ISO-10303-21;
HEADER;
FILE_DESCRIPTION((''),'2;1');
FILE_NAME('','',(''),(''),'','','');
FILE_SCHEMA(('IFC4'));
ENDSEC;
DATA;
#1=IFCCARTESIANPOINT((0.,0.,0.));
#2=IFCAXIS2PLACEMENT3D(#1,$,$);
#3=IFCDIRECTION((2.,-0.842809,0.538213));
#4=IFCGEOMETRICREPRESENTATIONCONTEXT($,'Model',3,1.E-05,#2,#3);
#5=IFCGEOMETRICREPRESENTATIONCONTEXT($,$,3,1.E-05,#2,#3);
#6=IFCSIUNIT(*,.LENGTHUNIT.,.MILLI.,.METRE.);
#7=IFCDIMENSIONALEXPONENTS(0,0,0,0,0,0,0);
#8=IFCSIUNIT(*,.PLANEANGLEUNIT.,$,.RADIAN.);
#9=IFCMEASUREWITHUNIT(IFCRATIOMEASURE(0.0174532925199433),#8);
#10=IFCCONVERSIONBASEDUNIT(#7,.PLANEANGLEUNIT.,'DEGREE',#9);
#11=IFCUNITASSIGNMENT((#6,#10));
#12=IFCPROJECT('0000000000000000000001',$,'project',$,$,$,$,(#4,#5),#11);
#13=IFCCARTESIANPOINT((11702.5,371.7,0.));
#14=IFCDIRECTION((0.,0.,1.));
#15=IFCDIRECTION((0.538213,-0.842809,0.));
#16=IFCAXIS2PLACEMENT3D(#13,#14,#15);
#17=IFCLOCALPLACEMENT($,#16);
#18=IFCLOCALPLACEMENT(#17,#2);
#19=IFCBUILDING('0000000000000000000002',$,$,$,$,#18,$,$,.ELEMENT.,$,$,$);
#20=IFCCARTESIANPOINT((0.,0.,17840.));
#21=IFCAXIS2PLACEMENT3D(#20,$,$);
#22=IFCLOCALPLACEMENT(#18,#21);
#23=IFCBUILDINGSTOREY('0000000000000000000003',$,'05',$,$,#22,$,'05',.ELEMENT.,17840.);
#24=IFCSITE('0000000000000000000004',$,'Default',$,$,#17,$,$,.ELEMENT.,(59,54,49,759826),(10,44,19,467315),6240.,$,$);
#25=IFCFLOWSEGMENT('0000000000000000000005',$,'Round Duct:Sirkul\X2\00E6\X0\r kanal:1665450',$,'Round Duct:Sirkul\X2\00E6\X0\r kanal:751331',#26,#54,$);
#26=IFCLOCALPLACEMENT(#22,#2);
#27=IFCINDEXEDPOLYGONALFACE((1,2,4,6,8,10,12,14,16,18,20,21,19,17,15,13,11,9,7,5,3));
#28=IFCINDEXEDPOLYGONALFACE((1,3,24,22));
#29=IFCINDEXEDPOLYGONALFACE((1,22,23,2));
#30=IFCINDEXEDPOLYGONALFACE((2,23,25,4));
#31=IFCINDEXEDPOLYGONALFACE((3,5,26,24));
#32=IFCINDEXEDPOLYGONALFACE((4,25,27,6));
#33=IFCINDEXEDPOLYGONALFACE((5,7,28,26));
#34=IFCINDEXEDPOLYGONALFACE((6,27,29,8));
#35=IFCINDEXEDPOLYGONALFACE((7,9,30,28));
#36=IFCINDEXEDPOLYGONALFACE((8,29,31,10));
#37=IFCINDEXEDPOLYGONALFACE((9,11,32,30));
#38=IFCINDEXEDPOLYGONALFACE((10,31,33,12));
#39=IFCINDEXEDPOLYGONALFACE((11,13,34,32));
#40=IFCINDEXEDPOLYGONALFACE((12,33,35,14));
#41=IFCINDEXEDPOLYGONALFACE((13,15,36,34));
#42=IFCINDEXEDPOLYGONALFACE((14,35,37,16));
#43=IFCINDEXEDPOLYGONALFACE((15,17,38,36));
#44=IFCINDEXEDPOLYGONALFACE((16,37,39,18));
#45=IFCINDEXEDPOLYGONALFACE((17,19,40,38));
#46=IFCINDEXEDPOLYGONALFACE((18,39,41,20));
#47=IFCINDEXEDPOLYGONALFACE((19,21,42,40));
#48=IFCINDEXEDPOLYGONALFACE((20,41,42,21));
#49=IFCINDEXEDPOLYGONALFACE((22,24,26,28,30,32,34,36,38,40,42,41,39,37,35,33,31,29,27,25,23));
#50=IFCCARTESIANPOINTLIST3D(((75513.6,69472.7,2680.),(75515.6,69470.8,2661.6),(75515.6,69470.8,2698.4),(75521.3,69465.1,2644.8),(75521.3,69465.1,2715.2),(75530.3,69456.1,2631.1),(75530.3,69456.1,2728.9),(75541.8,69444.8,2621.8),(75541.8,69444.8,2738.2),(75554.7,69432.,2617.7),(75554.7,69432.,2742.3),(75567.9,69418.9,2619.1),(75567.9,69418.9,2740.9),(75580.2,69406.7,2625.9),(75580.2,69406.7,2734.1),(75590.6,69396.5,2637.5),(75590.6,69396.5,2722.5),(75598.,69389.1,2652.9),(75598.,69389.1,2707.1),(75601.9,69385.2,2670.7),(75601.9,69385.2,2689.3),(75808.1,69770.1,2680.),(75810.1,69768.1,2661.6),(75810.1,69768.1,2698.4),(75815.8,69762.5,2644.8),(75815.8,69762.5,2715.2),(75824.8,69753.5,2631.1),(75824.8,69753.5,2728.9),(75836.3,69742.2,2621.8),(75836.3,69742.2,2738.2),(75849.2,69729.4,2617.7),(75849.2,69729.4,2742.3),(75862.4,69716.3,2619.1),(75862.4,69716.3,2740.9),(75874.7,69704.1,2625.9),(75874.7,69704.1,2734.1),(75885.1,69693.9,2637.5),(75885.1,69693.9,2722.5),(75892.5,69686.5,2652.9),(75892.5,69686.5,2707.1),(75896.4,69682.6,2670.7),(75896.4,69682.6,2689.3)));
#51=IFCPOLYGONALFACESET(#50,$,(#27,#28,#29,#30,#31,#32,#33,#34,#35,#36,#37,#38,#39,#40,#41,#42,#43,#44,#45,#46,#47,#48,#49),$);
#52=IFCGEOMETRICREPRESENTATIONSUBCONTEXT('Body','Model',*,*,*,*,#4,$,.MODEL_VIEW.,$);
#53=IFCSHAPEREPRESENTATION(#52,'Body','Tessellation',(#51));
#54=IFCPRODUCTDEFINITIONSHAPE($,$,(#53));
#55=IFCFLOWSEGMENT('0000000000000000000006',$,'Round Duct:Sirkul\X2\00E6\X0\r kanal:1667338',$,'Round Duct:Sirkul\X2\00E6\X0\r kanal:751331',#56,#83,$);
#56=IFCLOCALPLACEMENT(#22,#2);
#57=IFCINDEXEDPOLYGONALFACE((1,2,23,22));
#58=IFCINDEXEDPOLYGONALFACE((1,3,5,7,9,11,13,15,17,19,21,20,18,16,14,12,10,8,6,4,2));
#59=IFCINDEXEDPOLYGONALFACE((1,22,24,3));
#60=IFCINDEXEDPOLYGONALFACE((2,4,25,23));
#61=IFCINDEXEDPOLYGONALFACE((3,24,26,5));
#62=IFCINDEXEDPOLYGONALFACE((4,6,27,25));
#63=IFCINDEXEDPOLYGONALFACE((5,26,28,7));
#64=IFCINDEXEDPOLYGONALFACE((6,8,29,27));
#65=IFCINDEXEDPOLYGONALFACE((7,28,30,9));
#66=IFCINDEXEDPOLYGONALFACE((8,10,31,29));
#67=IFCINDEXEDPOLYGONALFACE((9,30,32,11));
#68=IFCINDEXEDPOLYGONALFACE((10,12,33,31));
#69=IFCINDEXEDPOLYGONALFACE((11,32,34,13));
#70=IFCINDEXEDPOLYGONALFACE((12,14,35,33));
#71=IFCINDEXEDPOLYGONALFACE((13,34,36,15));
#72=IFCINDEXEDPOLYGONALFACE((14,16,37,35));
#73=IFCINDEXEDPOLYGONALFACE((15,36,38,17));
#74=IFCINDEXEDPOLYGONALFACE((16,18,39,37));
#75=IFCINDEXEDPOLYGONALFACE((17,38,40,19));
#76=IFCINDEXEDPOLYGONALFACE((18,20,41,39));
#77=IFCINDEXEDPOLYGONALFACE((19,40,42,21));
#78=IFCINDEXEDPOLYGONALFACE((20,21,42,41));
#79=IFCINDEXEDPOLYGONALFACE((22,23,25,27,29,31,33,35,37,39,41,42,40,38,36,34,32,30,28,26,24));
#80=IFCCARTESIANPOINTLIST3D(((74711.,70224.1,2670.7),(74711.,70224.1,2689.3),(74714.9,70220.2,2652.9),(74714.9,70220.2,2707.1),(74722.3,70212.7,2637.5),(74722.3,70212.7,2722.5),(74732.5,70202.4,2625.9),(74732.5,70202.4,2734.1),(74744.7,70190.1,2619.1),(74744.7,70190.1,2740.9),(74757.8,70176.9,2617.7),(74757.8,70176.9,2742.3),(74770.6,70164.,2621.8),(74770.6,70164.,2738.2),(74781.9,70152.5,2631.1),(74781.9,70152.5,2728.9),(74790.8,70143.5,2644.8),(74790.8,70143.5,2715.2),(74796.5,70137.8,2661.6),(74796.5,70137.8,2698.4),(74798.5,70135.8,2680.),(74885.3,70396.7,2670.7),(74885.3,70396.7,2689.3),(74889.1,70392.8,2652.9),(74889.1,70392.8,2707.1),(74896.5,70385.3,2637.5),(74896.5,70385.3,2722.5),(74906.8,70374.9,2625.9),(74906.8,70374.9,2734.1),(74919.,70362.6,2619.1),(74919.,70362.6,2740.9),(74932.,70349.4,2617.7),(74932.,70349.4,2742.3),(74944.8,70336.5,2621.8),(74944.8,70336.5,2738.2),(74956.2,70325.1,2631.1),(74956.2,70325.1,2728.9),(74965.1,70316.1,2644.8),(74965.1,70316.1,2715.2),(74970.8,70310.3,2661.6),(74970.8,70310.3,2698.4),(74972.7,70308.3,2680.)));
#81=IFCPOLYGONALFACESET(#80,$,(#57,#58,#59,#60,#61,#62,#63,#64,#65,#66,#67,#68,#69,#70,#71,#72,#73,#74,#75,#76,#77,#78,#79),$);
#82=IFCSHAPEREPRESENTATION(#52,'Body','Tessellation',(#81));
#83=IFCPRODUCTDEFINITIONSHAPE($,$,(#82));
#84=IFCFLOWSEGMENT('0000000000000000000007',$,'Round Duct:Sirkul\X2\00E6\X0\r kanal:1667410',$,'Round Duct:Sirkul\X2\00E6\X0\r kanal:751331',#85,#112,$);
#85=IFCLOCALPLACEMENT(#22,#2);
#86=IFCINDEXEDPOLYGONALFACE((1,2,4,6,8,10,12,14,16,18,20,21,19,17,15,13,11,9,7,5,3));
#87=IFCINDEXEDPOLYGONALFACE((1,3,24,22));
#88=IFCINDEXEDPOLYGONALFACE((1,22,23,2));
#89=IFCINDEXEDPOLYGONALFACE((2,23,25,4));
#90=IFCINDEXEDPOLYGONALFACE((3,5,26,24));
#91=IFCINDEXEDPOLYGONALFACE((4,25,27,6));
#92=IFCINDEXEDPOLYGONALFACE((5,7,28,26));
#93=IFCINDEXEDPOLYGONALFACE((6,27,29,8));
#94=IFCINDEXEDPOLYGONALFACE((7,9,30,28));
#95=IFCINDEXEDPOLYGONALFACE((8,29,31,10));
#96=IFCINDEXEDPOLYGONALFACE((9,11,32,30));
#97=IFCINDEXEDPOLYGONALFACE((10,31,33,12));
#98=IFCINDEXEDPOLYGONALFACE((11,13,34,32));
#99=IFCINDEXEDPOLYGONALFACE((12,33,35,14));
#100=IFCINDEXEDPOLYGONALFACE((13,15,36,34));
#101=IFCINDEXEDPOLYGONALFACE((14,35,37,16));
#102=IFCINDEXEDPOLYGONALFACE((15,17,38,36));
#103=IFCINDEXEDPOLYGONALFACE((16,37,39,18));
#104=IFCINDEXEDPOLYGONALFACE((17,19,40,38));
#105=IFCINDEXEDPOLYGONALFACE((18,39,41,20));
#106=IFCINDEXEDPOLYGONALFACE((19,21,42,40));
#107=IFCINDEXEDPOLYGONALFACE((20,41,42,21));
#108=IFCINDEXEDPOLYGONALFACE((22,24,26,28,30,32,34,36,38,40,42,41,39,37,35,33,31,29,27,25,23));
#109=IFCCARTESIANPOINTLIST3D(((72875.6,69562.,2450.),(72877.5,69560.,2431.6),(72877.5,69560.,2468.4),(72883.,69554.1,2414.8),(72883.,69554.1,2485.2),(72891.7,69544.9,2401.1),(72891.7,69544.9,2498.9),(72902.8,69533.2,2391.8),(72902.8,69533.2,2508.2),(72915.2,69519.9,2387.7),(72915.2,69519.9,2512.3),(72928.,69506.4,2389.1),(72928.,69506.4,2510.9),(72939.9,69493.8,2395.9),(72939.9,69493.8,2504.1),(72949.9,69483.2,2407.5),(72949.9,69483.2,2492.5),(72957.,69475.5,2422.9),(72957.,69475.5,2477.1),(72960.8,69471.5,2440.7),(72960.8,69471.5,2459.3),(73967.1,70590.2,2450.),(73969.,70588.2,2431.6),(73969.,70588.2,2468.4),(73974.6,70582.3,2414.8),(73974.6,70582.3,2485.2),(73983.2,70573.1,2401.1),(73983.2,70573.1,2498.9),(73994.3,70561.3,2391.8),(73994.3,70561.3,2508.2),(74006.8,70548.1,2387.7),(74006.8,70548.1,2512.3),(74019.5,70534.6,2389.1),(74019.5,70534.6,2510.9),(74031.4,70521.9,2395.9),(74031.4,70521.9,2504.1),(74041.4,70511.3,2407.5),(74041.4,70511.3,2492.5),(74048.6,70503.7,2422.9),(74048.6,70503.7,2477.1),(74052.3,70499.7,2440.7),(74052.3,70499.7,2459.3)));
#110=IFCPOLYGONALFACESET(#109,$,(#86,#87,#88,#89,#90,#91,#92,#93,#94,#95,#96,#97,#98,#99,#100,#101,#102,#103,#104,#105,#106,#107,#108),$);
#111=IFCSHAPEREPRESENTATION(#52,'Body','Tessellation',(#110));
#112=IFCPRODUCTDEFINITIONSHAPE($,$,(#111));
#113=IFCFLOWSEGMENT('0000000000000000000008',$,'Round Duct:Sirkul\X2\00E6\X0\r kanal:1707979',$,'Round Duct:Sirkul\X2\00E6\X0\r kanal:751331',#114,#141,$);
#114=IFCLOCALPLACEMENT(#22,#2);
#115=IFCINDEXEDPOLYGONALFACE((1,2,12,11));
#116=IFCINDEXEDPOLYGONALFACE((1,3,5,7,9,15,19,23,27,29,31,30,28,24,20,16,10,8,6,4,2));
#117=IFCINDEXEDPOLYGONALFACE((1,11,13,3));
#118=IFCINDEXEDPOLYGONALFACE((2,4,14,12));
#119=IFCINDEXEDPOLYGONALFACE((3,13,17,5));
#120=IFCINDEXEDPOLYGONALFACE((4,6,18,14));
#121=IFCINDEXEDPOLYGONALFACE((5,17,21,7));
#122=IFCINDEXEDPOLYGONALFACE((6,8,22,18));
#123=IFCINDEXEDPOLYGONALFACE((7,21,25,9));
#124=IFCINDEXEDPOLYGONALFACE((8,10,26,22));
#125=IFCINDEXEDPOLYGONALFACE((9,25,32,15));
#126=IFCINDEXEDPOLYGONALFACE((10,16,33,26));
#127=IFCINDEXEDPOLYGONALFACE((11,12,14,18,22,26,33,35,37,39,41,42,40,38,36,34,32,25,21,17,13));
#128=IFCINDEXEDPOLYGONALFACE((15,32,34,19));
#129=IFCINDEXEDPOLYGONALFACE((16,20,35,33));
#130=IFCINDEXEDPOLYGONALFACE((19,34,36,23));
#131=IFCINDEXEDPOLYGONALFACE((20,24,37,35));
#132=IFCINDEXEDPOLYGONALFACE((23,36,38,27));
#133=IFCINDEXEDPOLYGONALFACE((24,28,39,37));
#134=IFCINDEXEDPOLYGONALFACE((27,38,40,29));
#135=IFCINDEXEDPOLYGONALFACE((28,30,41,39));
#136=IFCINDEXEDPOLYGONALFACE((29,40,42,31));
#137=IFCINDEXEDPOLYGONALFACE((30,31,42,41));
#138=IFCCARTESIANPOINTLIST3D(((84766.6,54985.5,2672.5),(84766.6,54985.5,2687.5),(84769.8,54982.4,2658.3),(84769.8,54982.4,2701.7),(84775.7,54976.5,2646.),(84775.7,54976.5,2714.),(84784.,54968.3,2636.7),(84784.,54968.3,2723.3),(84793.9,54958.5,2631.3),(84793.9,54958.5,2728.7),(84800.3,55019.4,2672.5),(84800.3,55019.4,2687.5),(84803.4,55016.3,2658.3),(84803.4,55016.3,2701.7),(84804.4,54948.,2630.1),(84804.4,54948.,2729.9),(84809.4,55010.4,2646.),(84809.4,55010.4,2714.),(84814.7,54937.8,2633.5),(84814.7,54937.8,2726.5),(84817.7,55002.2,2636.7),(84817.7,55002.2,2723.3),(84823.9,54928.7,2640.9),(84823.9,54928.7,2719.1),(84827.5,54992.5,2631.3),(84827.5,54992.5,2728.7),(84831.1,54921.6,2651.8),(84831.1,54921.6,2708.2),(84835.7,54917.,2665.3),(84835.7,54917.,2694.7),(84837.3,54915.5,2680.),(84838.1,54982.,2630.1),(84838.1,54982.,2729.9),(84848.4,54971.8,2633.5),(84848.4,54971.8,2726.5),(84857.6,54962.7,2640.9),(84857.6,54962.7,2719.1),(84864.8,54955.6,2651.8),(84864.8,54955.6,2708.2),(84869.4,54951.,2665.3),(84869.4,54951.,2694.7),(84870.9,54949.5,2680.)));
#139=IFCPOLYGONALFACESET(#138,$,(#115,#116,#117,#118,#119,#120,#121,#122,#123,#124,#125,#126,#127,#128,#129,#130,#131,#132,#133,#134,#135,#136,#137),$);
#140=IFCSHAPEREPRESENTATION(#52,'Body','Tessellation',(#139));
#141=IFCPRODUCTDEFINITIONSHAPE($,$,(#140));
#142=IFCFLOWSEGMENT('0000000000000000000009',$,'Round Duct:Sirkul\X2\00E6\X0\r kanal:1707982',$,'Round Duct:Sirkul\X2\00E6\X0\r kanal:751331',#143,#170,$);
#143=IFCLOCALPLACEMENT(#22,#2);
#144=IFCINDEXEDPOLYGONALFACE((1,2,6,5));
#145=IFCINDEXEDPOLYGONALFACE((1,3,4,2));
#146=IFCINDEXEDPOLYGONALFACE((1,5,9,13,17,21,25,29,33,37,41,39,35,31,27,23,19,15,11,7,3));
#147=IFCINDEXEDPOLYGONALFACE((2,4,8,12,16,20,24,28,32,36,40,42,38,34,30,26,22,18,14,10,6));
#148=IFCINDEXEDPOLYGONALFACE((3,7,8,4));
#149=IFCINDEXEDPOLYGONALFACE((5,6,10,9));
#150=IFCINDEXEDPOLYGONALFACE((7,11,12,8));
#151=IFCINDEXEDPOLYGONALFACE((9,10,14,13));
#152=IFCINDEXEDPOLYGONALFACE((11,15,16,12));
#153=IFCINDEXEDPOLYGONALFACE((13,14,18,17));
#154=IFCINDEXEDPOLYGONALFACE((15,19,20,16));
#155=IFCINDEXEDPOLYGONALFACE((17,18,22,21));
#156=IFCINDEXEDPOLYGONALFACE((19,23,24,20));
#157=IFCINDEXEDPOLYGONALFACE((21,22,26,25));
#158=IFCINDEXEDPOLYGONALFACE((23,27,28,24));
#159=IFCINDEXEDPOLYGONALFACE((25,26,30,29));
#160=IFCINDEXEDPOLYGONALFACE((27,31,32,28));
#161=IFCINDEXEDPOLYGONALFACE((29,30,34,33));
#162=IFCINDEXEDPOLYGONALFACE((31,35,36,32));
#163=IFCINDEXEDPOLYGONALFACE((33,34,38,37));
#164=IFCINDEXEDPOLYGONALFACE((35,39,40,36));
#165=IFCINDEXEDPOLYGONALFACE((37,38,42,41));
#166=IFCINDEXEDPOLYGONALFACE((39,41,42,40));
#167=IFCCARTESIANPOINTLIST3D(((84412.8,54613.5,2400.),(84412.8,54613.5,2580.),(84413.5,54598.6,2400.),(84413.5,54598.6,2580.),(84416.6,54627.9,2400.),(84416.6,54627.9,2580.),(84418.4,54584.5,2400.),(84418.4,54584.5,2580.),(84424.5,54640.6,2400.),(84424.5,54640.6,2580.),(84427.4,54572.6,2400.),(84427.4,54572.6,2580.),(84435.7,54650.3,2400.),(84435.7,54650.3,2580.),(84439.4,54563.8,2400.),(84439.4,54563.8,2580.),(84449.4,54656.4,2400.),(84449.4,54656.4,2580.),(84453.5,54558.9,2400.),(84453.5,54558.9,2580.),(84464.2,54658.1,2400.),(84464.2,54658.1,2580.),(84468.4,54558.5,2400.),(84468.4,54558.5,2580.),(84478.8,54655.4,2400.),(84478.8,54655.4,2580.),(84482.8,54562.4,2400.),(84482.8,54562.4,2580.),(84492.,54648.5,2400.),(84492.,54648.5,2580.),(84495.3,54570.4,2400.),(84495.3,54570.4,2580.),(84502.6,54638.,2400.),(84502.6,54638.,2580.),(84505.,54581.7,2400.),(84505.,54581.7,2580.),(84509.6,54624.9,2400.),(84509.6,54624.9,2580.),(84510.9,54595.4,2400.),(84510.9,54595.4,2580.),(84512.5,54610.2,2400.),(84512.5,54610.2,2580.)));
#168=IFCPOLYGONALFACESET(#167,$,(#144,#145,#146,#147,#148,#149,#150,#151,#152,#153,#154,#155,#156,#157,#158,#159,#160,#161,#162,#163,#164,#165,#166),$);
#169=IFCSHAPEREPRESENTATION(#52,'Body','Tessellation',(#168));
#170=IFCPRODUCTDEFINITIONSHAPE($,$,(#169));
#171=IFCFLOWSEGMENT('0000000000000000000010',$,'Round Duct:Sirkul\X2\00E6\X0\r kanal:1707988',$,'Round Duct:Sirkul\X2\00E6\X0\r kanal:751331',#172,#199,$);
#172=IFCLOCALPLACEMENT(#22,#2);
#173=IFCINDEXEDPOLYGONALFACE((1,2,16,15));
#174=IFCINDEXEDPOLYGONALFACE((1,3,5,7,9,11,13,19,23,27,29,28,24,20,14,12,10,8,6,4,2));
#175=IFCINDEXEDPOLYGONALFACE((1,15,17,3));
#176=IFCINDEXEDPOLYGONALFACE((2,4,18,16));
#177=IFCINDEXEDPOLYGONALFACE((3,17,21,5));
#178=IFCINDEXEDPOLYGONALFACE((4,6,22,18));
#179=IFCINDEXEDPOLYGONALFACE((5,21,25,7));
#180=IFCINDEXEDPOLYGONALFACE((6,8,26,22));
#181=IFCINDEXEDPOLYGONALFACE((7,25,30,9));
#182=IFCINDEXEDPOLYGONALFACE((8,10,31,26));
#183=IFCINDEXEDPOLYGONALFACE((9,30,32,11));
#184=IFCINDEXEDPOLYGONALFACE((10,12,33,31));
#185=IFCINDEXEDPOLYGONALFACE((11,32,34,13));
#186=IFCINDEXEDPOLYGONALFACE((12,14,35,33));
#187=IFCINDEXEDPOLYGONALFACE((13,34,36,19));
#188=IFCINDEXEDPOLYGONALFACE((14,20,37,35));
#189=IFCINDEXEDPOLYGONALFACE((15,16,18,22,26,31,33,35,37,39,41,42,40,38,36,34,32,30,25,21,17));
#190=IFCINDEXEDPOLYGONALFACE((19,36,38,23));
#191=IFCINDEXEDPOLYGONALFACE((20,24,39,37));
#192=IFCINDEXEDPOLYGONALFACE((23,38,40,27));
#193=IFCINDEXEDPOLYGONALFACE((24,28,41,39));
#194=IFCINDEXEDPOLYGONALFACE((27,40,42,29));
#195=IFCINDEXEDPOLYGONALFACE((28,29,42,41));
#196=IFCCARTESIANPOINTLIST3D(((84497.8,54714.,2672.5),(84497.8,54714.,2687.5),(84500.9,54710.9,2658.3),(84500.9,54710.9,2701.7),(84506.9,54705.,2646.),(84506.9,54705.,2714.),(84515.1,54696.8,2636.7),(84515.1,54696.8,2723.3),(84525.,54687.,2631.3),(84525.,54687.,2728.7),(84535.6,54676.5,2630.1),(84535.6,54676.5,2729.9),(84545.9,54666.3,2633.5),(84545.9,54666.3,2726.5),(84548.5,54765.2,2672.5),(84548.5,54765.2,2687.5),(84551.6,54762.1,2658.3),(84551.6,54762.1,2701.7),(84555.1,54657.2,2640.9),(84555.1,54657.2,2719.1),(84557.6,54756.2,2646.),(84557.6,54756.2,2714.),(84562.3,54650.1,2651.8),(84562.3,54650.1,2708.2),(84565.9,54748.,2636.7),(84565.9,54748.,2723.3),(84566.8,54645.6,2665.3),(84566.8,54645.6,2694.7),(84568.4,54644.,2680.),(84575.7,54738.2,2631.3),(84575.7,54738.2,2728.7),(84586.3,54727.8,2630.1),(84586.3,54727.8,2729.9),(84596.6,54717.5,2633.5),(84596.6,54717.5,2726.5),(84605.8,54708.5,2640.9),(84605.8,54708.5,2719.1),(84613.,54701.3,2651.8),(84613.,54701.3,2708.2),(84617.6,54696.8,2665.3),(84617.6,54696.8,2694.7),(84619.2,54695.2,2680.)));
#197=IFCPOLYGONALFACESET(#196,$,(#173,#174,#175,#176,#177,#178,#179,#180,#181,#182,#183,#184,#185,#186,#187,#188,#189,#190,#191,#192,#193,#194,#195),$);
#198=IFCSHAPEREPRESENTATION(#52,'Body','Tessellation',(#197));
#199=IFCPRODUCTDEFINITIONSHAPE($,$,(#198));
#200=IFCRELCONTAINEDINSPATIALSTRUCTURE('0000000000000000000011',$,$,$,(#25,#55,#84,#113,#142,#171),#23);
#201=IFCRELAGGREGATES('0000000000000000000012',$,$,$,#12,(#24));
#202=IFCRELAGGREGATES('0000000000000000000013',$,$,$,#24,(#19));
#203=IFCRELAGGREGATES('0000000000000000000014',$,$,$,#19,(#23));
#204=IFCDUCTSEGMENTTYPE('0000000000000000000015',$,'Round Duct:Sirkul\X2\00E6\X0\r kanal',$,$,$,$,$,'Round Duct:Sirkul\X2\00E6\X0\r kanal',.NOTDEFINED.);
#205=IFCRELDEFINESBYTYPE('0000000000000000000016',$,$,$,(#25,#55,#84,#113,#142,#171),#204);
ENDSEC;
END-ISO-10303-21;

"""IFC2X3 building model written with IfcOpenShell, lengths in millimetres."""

from ifc_helpers import new_model, entity, si_unit, converted_unit, direction, frame, frame_2d, origin, origin_2d_with_axis, place, context, subcontext, project, spatial, circle, extrude, type_object, element, save


model = new_model("IFC2X3")

# Units and contexts
model_context = context("Model", 3, precision=1e-05, world=origin(), true_north=direction((2.0, -0.842809, 0.538213)))
context_of_model = context(None, 3, precision=1e-05, world=origin(), true_north=direction((2.0, -0.842809, 0.538213)))
body_context = subcontext(model_context, "Body", "Model", "MODEL_VIEW")
ifc_project = project(units=[si_unit("LENGTHUNIT", "METRE", prefix="MILLI"), converted_unit("PLANEANGLEUNIT", "DEGREE", entity("IfcRatioMeasure", 0.0174532925199433), si_unit("PLANEANGLEUNIT", "RADIAN"), dimensions=[0, 0, 0, 0, 0, 0, 0])], contexts=[model_context, context_of_model])

# Site, building, storey
site_placement = place(None, frame((11702.5, 371.7, 0.0), z_axis=(0.0, 0.0, 1.0), x_axis=(0.538213, -0.842809, 0.0)))
site = spatial("IfcSite", under=ifc_project, at=site_placement, Name="Default", CompositionType="ELEMENT", RefLatitude=(59, 54, 49, 759826), RefLongitude=(10, 44, 19, 467315), RefElevation=6240.0)
building_placement = place(site_placement, origin())
building = spatial("IfcBuilding", under=site, at=building_placement, CompositionType="ELEMENT")
storey_placement = place(building_placement, frame((0.0, 0.0, 17840.0)))
storey = spatial("IfcBuildingStorey", under=building, at=storey_placement, Name="05", LongName="05", CompositionType="ELEMENT", Elevation=17840.0)

# Flow segments
duct_segment_type = type_object("IfcDuctSegmentType", Name="Round Duct:Sirkulær kanal", ElementType="Round Duct:Sirkulær kanal", PredefinedType="NOTDEFINED")
flow_segment_1_placement = place(storey_placement, origin())
element("IfcFlowSegment", 1, at=flow_segment_1_placement, inside=storey, type_object=duct_segment_type, Name="Round Duct:Sirkulær kanal:1665450", ObjectType="Round Duct:Sirkulær kanal:751331", context=body_context, shape_type="SweptSolid", body=[
    extrude(circle(Radius=62.5, at=frame_2d((0.0, 0.0), x_axis=(1.0, 0.0))), frame((75558.0, 69428.7, 2680.0), z_axis=(0.703669, 0.710528, 0.0), x_axis=(-0.710528, 0.703669, 0.0)), (0.0, 0.0, 1.0), 418.5),
])
flow_segment_2_placement = place(storey_placement, origin())
element("IfcFlowSegment", 2, at=flow_segment_2_placement, inside=storey, type_object=duct_segment_type, Name="Round Duct:Sirkulær kanal:1667338", ObjectType="Round Duct:Sirkulær kanal:751331", context=body_context, shape_type="SweptSolid", body=[
    extrude(circle(Radius=62.5, at=frame_2d((0.0, 0.0), x_axis=(1.0, 0.0))), frame((74754.5, 70180.2, 2680.0), z_axis=(0.710554, 0.703643, 0.0), x_axis=(0.703643, -0.710554, 0.0)), (0.0, 0.0, 1.0), 245.2),
])
flow_segment_3_placement = place(storey_placement, origin())
element("IfcFlowSegment", 3, at=flow_segment_3_placement, inside=storey, type_object=duct_segment_type, Name="Round Duct:Sirkulær kanal:1667410", ObjectType="Round Duct:Sirkulær kanal:751331", context=body_context, shape_type="SweptSolid", body=[
    extrude(circle(Radius=62.5, at=origin_2d_with_axis()), frame((72918.4, 69516.5, 2450.0), z_axis=(0.72792, 0.685662, 0.0), x_axis=(-0.685662, 0.72792, 0.0)), (0.0, 0.0, 1.0), 1499.5),
])
flow_segment_4_placement = place(storey_placement, origin())
element("IfcFlowSegment", 4, at=flow_segment_4_placement, inside=storey, type_object=duct_segment_type, Name="Round Duct:Sirkulær kanal:1707979", ObjectType="Round Duct:Sirkulær kanal:751331", context=body_context, shape_type="SweptSolid", body=[
    extrude(circle(Radius=50.0, at=origin_2d_with_axis()), frame((84801.8, 54950.7, 2680.0), z_axis=(0.703669, 0.710528, 0.0), x_axis=(0.710528, -0.703669, 0.0)), (0.0, 0.0, 1.0), 47.8),
])
flow_segment_5_placement = place(storey_placement, origin())
element("IfcFlowSegment", 5, at=flow_segment_5_placement, inside=storey, type_object=duct_segment_type, Name="Round Duct:Sirkulær kanal:1707982", ObjectType="Round Duct:Sirkulær kanal:751331", context=body_context, shape_type="SweptSolid", body=[
    extrude(circle(Radius=50.0, at=origin_2d_with_axis()), frame((84462.5, 54608.1, 2400.0), z_axis=(0.0, 0.0, 1.0), x_axis=(-0.703669, -0.710528, 0.0)), (0.0, 0.0, 1.0), 180.0),
])
flow_segment_6_placement = place(storey_placement, origin())
element("IfcFlowSegment", 6, at=flow_segment_6_placement, inside=storey, type_object=duct_segment_type, Name="Round Duct:Sirkulær kanal:1707988", ObjectType="Round Duct:Sirkulær kanal:751331", context=body_context, shape_type="SweptSolid", body=[
    extrude(circle(Radius=50.0, at=origin_2d_with_axis()), frame((84532.9, 54679.2, 2680.0), z_axis=(0.703669, 0.710528, 0.0), x_axis=(0.710528, -0.703669, 0.0)), (0.0, 0.0, 1.0), 72.1),
])

save(model, "model.ifc")
